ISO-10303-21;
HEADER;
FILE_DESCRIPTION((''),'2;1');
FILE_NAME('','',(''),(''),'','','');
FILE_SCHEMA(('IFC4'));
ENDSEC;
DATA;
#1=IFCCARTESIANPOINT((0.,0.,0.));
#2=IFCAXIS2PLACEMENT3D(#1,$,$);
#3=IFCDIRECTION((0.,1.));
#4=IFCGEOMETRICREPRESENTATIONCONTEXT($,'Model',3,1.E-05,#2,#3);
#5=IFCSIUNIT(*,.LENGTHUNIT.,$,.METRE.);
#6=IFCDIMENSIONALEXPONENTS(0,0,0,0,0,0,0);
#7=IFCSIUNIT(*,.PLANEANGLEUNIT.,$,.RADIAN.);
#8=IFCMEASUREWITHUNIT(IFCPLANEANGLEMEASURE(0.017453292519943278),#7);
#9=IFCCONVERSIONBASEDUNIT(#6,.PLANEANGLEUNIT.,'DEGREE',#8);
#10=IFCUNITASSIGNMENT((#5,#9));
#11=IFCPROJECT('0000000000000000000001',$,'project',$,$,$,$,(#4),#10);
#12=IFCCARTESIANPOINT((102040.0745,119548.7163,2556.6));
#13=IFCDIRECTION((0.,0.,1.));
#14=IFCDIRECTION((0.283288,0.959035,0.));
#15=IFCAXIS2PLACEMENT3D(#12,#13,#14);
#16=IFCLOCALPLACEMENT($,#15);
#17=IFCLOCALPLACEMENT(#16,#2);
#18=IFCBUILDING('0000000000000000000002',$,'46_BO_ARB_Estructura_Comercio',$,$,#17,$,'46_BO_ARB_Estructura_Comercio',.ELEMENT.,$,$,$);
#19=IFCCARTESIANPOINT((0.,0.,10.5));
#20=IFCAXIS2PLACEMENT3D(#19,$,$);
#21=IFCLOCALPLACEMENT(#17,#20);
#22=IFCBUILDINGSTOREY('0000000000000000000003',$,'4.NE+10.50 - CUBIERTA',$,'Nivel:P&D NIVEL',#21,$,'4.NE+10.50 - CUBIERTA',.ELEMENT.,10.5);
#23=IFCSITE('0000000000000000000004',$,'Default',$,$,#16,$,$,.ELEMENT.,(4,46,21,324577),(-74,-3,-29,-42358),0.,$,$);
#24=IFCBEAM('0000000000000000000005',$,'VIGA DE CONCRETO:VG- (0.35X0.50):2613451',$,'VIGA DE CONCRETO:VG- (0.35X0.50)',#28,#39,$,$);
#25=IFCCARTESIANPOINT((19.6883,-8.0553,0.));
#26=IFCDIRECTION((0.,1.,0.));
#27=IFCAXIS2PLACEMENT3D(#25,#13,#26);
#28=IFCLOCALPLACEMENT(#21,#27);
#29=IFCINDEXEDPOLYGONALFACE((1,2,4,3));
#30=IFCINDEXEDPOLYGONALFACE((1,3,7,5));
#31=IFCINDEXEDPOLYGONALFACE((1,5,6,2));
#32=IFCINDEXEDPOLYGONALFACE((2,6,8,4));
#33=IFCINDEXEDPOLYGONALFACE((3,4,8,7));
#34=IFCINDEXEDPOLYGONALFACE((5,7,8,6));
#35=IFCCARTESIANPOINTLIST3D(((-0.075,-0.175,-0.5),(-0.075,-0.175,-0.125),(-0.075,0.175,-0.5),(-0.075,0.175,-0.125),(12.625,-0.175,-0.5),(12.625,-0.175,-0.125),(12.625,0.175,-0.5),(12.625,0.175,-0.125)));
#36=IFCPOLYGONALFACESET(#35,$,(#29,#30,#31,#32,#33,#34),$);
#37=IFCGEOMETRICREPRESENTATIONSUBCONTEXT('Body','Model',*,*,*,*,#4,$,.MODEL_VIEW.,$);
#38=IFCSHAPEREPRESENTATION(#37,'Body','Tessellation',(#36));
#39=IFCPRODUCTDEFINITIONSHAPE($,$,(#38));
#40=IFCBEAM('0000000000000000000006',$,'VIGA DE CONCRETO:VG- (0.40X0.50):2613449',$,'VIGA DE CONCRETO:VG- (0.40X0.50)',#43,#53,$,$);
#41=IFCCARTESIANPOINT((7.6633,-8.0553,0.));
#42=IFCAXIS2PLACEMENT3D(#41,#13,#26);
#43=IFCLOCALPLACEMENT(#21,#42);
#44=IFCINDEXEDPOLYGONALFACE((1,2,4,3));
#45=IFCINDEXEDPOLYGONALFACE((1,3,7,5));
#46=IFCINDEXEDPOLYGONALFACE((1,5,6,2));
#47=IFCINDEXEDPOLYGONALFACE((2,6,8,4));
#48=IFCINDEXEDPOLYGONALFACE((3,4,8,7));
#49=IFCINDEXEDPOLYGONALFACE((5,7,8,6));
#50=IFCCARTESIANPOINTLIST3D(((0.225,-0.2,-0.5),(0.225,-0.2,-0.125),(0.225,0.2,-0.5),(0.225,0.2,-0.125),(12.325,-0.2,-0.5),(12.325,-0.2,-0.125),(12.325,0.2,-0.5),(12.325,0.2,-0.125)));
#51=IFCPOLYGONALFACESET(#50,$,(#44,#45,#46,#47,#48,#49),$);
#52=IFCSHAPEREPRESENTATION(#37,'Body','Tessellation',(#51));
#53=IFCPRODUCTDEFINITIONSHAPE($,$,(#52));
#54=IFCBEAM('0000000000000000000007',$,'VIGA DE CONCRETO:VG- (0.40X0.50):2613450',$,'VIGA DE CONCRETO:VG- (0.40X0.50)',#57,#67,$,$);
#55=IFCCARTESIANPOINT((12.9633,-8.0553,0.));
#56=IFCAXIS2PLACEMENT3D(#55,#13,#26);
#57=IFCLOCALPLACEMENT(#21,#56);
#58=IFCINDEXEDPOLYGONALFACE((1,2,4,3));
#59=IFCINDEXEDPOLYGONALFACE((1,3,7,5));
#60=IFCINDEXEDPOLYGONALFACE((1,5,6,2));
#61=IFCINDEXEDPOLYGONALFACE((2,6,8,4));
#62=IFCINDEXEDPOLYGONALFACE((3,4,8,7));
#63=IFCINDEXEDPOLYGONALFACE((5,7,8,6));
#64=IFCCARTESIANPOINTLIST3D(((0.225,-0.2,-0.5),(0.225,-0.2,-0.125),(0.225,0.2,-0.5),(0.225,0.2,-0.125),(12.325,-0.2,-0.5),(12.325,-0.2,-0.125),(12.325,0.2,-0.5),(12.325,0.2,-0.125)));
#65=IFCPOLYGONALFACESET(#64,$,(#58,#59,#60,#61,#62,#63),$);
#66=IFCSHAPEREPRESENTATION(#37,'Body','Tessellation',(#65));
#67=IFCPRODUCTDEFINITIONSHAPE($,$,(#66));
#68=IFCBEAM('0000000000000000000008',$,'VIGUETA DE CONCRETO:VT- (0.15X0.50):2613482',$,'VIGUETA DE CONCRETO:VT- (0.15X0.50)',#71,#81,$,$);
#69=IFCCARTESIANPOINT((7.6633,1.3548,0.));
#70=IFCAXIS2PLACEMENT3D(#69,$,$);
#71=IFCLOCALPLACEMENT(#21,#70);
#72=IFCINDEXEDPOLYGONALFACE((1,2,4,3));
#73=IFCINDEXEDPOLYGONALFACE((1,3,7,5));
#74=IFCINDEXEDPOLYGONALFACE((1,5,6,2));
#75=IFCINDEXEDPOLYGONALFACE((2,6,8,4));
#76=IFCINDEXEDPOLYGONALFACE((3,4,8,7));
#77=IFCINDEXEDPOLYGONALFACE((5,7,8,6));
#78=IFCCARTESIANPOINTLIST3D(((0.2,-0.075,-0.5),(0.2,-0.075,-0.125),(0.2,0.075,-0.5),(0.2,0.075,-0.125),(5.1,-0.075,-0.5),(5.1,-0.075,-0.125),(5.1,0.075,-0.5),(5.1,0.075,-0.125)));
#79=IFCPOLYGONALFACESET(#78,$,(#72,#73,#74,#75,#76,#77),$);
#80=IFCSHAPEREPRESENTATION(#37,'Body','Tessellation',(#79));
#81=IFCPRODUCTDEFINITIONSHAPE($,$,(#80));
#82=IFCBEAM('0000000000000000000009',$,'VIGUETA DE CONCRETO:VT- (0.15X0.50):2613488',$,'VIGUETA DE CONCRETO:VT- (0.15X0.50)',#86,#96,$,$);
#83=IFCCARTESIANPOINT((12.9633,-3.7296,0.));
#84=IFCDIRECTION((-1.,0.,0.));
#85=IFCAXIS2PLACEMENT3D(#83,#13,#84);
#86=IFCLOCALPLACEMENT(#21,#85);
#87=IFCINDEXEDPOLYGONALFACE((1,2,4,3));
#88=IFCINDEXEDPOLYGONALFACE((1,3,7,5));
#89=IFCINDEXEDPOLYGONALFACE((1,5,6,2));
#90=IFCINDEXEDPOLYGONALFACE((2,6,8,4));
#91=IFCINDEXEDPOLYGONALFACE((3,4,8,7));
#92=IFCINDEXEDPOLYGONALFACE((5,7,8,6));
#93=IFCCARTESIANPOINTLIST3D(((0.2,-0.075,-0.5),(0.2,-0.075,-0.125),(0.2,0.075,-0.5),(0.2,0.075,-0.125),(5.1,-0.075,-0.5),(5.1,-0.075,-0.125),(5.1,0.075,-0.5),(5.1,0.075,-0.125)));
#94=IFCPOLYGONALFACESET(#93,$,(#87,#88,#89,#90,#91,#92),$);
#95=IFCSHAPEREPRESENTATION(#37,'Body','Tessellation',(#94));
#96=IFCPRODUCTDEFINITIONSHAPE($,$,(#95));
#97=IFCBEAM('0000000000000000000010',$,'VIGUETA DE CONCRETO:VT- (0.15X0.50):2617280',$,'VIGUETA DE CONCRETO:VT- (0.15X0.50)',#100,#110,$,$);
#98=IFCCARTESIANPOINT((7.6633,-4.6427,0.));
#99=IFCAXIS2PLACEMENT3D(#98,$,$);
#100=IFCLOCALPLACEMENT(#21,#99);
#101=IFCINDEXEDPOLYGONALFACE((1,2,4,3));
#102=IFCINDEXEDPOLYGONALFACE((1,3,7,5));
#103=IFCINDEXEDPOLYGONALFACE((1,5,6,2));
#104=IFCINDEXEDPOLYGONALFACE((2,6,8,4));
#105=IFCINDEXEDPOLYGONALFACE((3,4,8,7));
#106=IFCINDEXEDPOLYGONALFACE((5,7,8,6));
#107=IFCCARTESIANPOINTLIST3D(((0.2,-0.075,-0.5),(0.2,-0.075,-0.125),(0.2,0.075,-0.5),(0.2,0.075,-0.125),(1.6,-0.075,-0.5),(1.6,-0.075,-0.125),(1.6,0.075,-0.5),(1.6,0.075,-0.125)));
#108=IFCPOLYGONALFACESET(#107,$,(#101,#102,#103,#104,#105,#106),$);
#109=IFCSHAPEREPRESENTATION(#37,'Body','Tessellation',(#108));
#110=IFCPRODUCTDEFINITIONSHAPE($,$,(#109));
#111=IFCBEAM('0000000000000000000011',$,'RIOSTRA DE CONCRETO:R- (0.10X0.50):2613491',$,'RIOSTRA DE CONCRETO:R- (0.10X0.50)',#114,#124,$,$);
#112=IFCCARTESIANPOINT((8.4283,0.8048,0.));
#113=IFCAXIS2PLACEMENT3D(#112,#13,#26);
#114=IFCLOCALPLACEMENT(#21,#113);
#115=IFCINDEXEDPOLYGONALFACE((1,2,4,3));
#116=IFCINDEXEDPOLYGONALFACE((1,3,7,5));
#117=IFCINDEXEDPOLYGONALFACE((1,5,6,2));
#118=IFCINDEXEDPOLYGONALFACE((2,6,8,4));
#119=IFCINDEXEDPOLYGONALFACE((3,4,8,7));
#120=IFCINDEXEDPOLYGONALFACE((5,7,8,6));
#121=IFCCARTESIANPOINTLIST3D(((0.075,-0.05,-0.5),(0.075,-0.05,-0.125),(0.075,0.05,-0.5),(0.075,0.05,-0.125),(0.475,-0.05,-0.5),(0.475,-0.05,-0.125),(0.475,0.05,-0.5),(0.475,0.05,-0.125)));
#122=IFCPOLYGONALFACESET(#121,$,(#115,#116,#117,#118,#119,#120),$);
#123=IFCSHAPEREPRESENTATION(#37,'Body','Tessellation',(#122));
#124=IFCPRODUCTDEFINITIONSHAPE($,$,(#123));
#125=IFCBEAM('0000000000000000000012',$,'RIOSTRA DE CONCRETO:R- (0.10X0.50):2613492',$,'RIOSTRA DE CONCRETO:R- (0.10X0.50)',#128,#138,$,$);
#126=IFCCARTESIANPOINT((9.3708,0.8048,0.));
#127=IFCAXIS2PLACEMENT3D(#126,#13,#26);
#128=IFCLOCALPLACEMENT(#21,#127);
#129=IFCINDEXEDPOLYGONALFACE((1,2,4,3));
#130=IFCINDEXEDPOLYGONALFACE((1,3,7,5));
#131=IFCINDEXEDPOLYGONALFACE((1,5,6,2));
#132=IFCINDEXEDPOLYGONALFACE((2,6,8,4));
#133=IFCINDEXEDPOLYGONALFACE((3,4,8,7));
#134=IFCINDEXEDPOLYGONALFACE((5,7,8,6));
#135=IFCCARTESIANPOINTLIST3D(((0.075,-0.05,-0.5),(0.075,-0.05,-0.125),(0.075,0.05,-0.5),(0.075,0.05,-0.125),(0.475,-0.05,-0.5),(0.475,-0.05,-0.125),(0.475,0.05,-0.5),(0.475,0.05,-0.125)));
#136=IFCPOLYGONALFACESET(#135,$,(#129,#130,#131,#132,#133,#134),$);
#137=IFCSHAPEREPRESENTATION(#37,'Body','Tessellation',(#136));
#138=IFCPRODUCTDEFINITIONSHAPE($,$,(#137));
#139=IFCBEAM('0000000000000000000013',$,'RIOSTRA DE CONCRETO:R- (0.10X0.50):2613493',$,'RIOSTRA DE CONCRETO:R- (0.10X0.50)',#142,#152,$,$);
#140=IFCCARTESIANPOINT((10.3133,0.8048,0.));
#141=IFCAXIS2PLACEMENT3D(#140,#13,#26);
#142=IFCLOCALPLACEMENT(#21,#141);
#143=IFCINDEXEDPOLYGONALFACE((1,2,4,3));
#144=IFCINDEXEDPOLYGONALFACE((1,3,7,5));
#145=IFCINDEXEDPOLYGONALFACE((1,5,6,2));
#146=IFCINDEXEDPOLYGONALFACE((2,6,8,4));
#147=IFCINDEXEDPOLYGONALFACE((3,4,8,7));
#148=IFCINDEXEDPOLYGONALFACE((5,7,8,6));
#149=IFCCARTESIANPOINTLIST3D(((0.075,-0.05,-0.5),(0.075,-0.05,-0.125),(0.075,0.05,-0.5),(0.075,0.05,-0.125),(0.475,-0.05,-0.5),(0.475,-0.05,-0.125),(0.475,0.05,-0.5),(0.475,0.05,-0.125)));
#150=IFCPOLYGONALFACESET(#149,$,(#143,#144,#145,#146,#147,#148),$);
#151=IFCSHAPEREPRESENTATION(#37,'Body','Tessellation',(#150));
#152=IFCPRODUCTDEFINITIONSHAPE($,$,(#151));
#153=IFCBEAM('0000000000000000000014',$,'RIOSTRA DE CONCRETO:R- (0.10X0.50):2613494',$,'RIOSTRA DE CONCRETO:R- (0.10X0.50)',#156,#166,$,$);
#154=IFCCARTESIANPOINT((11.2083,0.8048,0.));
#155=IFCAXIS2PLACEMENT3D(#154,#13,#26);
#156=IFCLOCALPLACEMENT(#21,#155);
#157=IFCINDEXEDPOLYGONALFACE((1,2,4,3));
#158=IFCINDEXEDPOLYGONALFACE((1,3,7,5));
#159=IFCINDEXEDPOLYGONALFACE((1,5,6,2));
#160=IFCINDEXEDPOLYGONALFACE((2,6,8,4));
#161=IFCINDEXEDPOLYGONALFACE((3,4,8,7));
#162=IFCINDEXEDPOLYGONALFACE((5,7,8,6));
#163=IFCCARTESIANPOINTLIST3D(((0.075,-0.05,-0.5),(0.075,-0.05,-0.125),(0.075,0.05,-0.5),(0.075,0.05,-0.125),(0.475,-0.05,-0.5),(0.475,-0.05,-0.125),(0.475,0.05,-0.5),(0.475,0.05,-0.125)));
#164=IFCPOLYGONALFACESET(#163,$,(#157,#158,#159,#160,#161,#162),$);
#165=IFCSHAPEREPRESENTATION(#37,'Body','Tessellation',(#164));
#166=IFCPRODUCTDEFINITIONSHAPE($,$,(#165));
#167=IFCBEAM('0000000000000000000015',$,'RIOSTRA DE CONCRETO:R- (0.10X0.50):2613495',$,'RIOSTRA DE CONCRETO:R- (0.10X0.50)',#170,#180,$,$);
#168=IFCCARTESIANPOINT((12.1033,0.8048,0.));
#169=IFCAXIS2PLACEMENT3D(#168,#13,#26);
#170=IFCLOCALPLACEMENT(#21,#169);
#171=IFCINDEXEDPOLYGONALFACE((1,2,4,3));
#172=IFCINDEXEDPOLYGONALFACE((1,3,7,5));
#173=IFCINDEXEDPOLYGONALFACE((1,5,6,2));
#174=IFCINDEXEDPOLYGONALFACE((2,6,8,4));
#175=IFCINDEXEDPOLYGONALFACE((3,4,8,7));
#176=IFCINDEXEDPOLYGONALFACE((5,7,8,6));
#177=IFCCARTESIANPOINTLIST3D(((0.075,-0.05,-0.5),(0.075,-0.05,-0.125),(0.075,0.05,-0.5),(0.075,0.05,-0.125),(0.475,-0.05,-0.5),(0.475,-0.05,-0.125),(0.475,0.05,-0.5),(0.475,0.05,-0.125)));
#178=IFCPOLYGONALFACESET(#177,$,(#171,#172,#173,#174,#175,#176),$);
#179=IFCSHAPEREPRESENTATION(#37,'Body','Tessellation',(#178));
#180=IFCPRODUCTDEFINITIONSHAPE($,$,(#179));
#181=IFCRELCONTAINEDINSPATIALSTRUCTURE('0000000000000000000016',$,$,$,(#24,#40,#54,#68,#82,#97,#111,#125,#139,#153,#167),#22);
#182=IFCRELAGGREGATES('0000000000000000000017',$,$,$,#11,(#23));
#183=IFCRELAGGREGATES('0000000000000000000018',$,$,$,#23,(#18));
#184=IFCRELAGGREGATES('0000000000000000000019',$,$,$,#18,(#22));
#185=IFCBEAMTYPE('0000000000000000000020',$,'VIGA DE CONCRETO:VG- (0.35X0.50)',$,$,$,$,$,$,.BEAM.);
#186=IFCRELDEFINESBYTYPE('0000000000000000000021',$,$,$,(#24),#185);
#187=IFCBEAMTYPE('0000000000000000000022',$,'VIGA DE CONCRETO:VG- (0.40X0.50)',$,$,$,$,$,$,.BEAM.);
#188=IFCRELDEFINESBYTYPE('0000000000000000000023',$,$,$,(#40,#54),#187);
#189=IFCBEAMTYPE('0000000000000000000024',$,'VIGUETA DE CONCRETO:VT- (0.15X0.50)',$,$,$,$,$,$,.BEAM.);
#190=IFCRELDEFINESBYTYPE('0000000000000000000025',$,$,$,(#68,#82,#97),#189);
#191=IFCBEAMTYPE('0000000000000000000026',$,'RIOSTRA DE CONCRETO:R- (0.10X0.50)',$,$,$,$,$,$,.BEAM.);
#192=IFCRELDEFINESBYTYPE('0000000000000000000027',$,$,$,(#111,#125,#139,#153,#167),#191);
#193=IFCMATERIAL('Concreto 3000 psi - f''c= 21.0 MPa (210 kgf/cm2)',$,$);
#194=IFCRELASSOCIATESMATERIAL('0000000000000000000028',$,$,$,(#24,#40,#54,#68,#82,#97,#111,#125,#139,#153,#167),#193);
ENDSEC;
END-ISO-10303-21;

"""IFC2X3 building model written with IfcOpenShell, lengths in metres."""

from ifc_helpers import new_model, entity, si_unit, converted_unit, direction, frame, frame_2d, origin, origin_2d_with_axis, place, context, subcontext, project, spatial, rectangle, extrude, material, type_object, element, save


model = new_model("IFC2X3")

# Units and contexts
model_context = context("Model", 3, precision=1e-05, world=origin(), true_north=direction((0.0, 1.0)))
body_context = subcontext(model_context, "Body", "Model", "MODEL_VIEW")
ifc_project = project(units=[si_unit("LENGTHUNIT", "METRE"), converted_unit("PLANEANGLEUNIT", "DEGREE", entity("IfcPlaneAngleMeasure", 0.017453292519943278), si_unit("PLANEANGLEUNIT", "RADIAN"), dimensions=[0, 0, 0, 0, 0, 0, 0])], contexts=[model_context])

# Site, building, storey
site_placement = place(None, frame((102040.0745, 119548.7163, 2556.6), z_axis=(0.0, 0.0, 1.0), x_axis=(0.283288, 0.959035, 0.0)))
site = spatial("IfcSite", under=ifc_project, at=site_placement, Name="Default", CompositionType="ELEMENT", RefLatitude=(4, 46, 21, 324577), RefLongitude=(-74, -3, -29, -42358), RefElevation=0.0)
building_placement = place(site_placement, origin())
building = spatial("IfcBuilding", under=site, at=building_placement, Name="46_BO_ARB_Estructura_Comercio", LongName="46_BO_ARB_Estructura_Comercio", CompositionType="ELEMENT")
storey_placement = place(building_placement, frame((0.0, 0.0, 10.5)))
storey = spatial("IfcBuildingStorey", under=building, at=storey_placement, Name="4.NE+10.50 - CUBIERTA", ObjectType="Nivel:P&D NIVEL", LongName="4.NE+10.50 - CUBIERTA", CompositionType="ELEMENT", Elevation=10.5)

# Beams
ifc_material = material(Name="Concreto 3000 psi - f'c= 21.0 MPa (210 kgf/cm2)")
beam_type_1 = type_object("IfcBeamType", Name="VIGA DE CONCRETO:VG- (0.35X0.50)", PredefinedType="BEAM")
beam_1_placement = place(storey_placement, frame((19.6883, -8.0553, 0.0), z_axis=(0.0, 0.0, 1.0), x_axis=(0.0, 1.0, 0.0)))
element("IfcBeam", 1, at=beam_1_placement, inside=storey, type_object=beam_type_1, material=ifc_material, Name="VIGA DE CONCRETO:VG- (0.35X0.50):2613451", ObjectType="VIGA DE CONCRETO:VG- (0.35X0.50)", context=body_context, shape_type="SweptSolid", body=[
    extrude(rectangle(XDim=0.375, YDim=0.35, at=frame_2d((0.0, 0.0), x_axis=(1.0, 0.0))), frame((-0.075, 0.0, -0.3125), z_axis=(1.0, 0.0, 0.0), x_axis=(0.0, 0.0, -1.0)), (0.0, 0.0, 1.0), 12.7),
])
beam_type_2 = type_object("IfcBeamType", Name="VIGA DE CONCRETO:VG- (0.40X0.50)", PredefinedType="BEAM")
beam_2_placement = place(storey_placement, frame((7.6633, -8.0553, 0.0), z_axis=(0.0, 0.0, 1.0), x_axis=(0.0, 1.0, 0.0)))
element("IfcBeam", 2, at=beam_2_placement, inside=storey, type_object=beam_type_2, material=ifc_material, Name="VIGA DE CONCRETO:VG- (0.40X0.50):2613449", ObjectType="VIGA DE CONCRETO:VG- (0.40X0.50)", context=body_context, shape_type="SweptSolid", body=[
    extrude(rectangle(XDim=0.375, YDim=0.4, at=origin_2d_with_axis()), frame((0.225, 0.0, -0.3125), z_axis=(1.0, 0.0, 0.0), x_axis=(0.0, 0.0, -1.0)), (0.0, 0.0, 1.0), 12.1),
])
beam_3_placement = place(storey_placement, frame((12.9633, -8.0553, 0.0), z_axis=(0.0, 0.0, 1.0), x_axis=(0.0, 1.0, 0.0)))
element("IfcBeam", 3, at=beam_3_placement, inside=storey, type_object=beam_type_2, material=ifc_material, Name="VIGA DE CONCRETO:VG- (0.40X0.50):2613450", ObjectType="VIGA DE CONCRETO:VG- (0.40X0.50)", context=body_context, shape_type="SweptSolid", body=[
    extrude(rectangle(XDim=0.375, YDim=0.4, at=origin_2d_with_axis()), frame((0.225, 0.0, -0.3125), z_axis=(1.0, 0.0, 0.0), x_axis=(0.0, 0.0, -1.0)), (0.0, 0.0, 1.0), 12.1),
])
beam_type_3 = type_object("IfcBeamType", Name="VIGUETA DE CONCRETO:VT- (0.15X0.50)", PredefinedType="BEAM")
beam_4_placement = place(storey_placement, frame((7.6633, 1.3548, 0.0)))
element("IfcBeam", 4, at=beam_4_placement, inside=storey, type_object=beam_type_3, material=ifc_material, Name="VIGUETA DE CONCRETO:VT- (0.15X0.50):2613482", ObjectType="VIGUETA DE CONCRETO:VT- (0.15X0.50)", context=body_context, shape_type="SweptSolid", body=[
    extrude(rectangle(XDim=0.375, YDim=0.15, at=frame_2d((0.0, 0.0), x_axis=(1.0, 0.0))), frame((0.2, 0.0, -0.3125), z_axis=(1.0, 0.0, 0.0), x_axis=(0.0, 0.0, -1.0)), (0.0, 0.0, 1.0), 4.9),
])
beam_5_placement = place(storey_placement, frame((12.9633, -3.7296, 0.0), z_axis=(0.0, 0.0, 1.0), x_axis=(-1.0, 0.0, 0.0)))
element("IfcBeam", 5, at=beam_5_placement, inside=storey, type_object=beam_type_3, material=ifc_material, Name="VIGUETA DE CONCRETO:VT- (0.15X0.50):2613488", ObjectType="VIGUETA DE CONCRETO:VT- (0.15X0.50)", context=body_context, shape_type="SweptSolid", body=[
    extrude(rectangle(XDim=0.375, YDim=0.15, at=frame_2d((0.0, 0.0), x_axis=(1.0, 0.0))), frame((0.2, 0.0, -0.3125), z_axis=(1.0, 0.0, 0.0), x_axis=(0.0, 0.0, -1.0)), (0.0, 0.0, 1.0), 4.9),
])
beam_6_placement = place(storey_placement, frame((7.6633, -4.6427, 0.0)))
element("IfcBeam", 6, at=beam_6_placement, inside=storey, type_object=beam_type_3, material=ifc_material, Name="VIGUETA DE CONCRETO:VT- (0.15X0.50):2617280", ObjectType="VIGUETA DE CONCRETO:VT- (0.15X0.50)", context=body_context, shape_type="SweptSolid", body=[
    extrude(rectangle(XDim=0.375, YDim=0.15, at=frame_2d((0.0, 0.0), x_axis=(1.0, 0.0))), frame((0.2, 0.0, -0.3125), z_axis=(1.0, 0.0, 0.0), x_axis=(0.0, 0.0, -1.0)), (0.0, 0.0, 1.0), 1.4),
])
beam_type_4 = type_object("IfcBeamType", Name="RIOSTRA DE CONCRETO:R- (0.10X0.50)", PredefinedType="BEAM")
beam_7_placement = place(storey_placement, frame((8.4283, 0.8048, 0.0), z_axis=(0.0, 0.0, 1.0), x_axis=(0.0, 1.0, 0.0)))
element("IfcBeam", 7, at=beam_7_placement, inside=storey, type_object=beam_type_4, material=ifc_material, Name="RIOSTRA DE CONCRETO:R- (0.10X0.50):2613491", ObjectType="RIOSTRA DE CONCRETO:R- (0.10X0.50)", context=body_context, shape_type="SweptSolid", body=[
    extrude(rectangle(XDim=0.375, YDim=0.1, at=frame_2d((0.0, 0.0), x_axis=(1.0, 0.0))), frame((0.075, 0.0, -0.3125), z_axis=(1.0, 0.0, 0.0), x_axis=(0.0, 0.0, -1.0)), (0.0, 0.0, 1.0), 0.4),
])
beam_8_placement = place(storey_placement, frame((9.3708, 0.8048, 0.0), z_axis=(0.0, 0.0, 1.0), x_axis=(0.0, 1.0, 0.0)))
element("IfcBeam", 8, at=beam_8_placement, inside=storey, type_object=beam_type_4, material=ifc_material, Name="RIOSTRA DE CONCRETO:R- (0.10X0.50):2613492", ObjectType="RIOSTRA DE CONCRETO:R- (0.10X0.50)", context=body_context, shape_type="SweptSolid", body=[
    extrude(rectangle(XDim=0.375, YDim=0.1, at=frame_2d((0.0, 0.0), x_axis=(1.0, 0.0))), frame((0.075, 0.0, -0.3125), z_axis=(1.0, 0.0, 0.0), x_axis=(0.0, 0.0, -1.0)), (0.0, 0.0, 1.0), 0.4),
])
beam_9_placement = place(storey_placement, frame((10.3133, 0.8048, 0.0), z_axis=(0.0, 0.0, 1.0), x_axis=(0.0, 1.0, 0.0)))
element("IfcBeam", 9, at=beam_9_placement, inside=storey, type_object=beam_type_4, material=ifc_material, Name="RIOSTRA DE CONCRETO:R- (0.10X0.50):2613493", ObjectType="RIOSTRA DE CONCRETO:R- (0.10X0.50)", context=body_context, shape_type="SweptSolid", body=[
    extrude(rectangle(XDim=0.375, YDim=0.1, at=origin_2d_with_axis()), frame((0.075, 0.0, -0.3125), z_axis=(1.0, 0.0, 0.0), x_axis=(0.0, 0.0, -1.0)), (0.0, 0.0, 1.0), 0.4),
])
beam_10_placement = place(storey_placement, frame((11.2083, 0.8048, 0.0), z_axis=(0.0, 0.0, 1.0), x_axis=(0.0, 1.0, 0.0)))
element("IfcBeam", 10, at=beam_10_placement, inside=storey, type_object=beam_type_4, material=ifc_material, Name="RIOSTRA DE CONCRETO:R- (0.10X0.50):2613494", ObjectType="RIOSTRA DE CONCRETO:R- (0.10X0.50)", context=body_context, shape_type="SweptSolid", body=[
    extrude(rectangle(XDim=0.375, YDim=0.1, at=origin_2d_with_axis()), frame((0.075, 0.0, -0.3125), z_axis=(1.0, 0.0, 0.0), x_axis=(0.0, 0.0, -1.0)), (0.0, 0.0, 1.0), 0.4),
])
beam_11_placement = place(storey_placement, frame((12.1033, 0.8048, 0.0), z_axis=(0.0, 0.0, 1.0), x_axis=(0.0, 1.0, 0.0)))
element("IfcBeam", 11, at=beam_11_placement, inside=storey, type_object=beam_type_4, material=ifc_material, Name="RIOSTRA DE CONCRETO:R- (0.10X0.50):2613495", ObjectType="RIOSTRA DE CONCRETO:R- (0.10X0.50)", context=body_context, shape_type="SweptSolid", body=[
    extrude(rectangle(XDim=0.375, YDim=0.1, at=origin_2d_with_axis()), frame((0.075, 0.0, -0.3125), z_axis=(1.0, 0.0, 0.0), x_axis=(0.0, 0.0, -1.0)), (0.0, 0.0, 1.0), 0.4),
])

save(model, "model.ifc")
